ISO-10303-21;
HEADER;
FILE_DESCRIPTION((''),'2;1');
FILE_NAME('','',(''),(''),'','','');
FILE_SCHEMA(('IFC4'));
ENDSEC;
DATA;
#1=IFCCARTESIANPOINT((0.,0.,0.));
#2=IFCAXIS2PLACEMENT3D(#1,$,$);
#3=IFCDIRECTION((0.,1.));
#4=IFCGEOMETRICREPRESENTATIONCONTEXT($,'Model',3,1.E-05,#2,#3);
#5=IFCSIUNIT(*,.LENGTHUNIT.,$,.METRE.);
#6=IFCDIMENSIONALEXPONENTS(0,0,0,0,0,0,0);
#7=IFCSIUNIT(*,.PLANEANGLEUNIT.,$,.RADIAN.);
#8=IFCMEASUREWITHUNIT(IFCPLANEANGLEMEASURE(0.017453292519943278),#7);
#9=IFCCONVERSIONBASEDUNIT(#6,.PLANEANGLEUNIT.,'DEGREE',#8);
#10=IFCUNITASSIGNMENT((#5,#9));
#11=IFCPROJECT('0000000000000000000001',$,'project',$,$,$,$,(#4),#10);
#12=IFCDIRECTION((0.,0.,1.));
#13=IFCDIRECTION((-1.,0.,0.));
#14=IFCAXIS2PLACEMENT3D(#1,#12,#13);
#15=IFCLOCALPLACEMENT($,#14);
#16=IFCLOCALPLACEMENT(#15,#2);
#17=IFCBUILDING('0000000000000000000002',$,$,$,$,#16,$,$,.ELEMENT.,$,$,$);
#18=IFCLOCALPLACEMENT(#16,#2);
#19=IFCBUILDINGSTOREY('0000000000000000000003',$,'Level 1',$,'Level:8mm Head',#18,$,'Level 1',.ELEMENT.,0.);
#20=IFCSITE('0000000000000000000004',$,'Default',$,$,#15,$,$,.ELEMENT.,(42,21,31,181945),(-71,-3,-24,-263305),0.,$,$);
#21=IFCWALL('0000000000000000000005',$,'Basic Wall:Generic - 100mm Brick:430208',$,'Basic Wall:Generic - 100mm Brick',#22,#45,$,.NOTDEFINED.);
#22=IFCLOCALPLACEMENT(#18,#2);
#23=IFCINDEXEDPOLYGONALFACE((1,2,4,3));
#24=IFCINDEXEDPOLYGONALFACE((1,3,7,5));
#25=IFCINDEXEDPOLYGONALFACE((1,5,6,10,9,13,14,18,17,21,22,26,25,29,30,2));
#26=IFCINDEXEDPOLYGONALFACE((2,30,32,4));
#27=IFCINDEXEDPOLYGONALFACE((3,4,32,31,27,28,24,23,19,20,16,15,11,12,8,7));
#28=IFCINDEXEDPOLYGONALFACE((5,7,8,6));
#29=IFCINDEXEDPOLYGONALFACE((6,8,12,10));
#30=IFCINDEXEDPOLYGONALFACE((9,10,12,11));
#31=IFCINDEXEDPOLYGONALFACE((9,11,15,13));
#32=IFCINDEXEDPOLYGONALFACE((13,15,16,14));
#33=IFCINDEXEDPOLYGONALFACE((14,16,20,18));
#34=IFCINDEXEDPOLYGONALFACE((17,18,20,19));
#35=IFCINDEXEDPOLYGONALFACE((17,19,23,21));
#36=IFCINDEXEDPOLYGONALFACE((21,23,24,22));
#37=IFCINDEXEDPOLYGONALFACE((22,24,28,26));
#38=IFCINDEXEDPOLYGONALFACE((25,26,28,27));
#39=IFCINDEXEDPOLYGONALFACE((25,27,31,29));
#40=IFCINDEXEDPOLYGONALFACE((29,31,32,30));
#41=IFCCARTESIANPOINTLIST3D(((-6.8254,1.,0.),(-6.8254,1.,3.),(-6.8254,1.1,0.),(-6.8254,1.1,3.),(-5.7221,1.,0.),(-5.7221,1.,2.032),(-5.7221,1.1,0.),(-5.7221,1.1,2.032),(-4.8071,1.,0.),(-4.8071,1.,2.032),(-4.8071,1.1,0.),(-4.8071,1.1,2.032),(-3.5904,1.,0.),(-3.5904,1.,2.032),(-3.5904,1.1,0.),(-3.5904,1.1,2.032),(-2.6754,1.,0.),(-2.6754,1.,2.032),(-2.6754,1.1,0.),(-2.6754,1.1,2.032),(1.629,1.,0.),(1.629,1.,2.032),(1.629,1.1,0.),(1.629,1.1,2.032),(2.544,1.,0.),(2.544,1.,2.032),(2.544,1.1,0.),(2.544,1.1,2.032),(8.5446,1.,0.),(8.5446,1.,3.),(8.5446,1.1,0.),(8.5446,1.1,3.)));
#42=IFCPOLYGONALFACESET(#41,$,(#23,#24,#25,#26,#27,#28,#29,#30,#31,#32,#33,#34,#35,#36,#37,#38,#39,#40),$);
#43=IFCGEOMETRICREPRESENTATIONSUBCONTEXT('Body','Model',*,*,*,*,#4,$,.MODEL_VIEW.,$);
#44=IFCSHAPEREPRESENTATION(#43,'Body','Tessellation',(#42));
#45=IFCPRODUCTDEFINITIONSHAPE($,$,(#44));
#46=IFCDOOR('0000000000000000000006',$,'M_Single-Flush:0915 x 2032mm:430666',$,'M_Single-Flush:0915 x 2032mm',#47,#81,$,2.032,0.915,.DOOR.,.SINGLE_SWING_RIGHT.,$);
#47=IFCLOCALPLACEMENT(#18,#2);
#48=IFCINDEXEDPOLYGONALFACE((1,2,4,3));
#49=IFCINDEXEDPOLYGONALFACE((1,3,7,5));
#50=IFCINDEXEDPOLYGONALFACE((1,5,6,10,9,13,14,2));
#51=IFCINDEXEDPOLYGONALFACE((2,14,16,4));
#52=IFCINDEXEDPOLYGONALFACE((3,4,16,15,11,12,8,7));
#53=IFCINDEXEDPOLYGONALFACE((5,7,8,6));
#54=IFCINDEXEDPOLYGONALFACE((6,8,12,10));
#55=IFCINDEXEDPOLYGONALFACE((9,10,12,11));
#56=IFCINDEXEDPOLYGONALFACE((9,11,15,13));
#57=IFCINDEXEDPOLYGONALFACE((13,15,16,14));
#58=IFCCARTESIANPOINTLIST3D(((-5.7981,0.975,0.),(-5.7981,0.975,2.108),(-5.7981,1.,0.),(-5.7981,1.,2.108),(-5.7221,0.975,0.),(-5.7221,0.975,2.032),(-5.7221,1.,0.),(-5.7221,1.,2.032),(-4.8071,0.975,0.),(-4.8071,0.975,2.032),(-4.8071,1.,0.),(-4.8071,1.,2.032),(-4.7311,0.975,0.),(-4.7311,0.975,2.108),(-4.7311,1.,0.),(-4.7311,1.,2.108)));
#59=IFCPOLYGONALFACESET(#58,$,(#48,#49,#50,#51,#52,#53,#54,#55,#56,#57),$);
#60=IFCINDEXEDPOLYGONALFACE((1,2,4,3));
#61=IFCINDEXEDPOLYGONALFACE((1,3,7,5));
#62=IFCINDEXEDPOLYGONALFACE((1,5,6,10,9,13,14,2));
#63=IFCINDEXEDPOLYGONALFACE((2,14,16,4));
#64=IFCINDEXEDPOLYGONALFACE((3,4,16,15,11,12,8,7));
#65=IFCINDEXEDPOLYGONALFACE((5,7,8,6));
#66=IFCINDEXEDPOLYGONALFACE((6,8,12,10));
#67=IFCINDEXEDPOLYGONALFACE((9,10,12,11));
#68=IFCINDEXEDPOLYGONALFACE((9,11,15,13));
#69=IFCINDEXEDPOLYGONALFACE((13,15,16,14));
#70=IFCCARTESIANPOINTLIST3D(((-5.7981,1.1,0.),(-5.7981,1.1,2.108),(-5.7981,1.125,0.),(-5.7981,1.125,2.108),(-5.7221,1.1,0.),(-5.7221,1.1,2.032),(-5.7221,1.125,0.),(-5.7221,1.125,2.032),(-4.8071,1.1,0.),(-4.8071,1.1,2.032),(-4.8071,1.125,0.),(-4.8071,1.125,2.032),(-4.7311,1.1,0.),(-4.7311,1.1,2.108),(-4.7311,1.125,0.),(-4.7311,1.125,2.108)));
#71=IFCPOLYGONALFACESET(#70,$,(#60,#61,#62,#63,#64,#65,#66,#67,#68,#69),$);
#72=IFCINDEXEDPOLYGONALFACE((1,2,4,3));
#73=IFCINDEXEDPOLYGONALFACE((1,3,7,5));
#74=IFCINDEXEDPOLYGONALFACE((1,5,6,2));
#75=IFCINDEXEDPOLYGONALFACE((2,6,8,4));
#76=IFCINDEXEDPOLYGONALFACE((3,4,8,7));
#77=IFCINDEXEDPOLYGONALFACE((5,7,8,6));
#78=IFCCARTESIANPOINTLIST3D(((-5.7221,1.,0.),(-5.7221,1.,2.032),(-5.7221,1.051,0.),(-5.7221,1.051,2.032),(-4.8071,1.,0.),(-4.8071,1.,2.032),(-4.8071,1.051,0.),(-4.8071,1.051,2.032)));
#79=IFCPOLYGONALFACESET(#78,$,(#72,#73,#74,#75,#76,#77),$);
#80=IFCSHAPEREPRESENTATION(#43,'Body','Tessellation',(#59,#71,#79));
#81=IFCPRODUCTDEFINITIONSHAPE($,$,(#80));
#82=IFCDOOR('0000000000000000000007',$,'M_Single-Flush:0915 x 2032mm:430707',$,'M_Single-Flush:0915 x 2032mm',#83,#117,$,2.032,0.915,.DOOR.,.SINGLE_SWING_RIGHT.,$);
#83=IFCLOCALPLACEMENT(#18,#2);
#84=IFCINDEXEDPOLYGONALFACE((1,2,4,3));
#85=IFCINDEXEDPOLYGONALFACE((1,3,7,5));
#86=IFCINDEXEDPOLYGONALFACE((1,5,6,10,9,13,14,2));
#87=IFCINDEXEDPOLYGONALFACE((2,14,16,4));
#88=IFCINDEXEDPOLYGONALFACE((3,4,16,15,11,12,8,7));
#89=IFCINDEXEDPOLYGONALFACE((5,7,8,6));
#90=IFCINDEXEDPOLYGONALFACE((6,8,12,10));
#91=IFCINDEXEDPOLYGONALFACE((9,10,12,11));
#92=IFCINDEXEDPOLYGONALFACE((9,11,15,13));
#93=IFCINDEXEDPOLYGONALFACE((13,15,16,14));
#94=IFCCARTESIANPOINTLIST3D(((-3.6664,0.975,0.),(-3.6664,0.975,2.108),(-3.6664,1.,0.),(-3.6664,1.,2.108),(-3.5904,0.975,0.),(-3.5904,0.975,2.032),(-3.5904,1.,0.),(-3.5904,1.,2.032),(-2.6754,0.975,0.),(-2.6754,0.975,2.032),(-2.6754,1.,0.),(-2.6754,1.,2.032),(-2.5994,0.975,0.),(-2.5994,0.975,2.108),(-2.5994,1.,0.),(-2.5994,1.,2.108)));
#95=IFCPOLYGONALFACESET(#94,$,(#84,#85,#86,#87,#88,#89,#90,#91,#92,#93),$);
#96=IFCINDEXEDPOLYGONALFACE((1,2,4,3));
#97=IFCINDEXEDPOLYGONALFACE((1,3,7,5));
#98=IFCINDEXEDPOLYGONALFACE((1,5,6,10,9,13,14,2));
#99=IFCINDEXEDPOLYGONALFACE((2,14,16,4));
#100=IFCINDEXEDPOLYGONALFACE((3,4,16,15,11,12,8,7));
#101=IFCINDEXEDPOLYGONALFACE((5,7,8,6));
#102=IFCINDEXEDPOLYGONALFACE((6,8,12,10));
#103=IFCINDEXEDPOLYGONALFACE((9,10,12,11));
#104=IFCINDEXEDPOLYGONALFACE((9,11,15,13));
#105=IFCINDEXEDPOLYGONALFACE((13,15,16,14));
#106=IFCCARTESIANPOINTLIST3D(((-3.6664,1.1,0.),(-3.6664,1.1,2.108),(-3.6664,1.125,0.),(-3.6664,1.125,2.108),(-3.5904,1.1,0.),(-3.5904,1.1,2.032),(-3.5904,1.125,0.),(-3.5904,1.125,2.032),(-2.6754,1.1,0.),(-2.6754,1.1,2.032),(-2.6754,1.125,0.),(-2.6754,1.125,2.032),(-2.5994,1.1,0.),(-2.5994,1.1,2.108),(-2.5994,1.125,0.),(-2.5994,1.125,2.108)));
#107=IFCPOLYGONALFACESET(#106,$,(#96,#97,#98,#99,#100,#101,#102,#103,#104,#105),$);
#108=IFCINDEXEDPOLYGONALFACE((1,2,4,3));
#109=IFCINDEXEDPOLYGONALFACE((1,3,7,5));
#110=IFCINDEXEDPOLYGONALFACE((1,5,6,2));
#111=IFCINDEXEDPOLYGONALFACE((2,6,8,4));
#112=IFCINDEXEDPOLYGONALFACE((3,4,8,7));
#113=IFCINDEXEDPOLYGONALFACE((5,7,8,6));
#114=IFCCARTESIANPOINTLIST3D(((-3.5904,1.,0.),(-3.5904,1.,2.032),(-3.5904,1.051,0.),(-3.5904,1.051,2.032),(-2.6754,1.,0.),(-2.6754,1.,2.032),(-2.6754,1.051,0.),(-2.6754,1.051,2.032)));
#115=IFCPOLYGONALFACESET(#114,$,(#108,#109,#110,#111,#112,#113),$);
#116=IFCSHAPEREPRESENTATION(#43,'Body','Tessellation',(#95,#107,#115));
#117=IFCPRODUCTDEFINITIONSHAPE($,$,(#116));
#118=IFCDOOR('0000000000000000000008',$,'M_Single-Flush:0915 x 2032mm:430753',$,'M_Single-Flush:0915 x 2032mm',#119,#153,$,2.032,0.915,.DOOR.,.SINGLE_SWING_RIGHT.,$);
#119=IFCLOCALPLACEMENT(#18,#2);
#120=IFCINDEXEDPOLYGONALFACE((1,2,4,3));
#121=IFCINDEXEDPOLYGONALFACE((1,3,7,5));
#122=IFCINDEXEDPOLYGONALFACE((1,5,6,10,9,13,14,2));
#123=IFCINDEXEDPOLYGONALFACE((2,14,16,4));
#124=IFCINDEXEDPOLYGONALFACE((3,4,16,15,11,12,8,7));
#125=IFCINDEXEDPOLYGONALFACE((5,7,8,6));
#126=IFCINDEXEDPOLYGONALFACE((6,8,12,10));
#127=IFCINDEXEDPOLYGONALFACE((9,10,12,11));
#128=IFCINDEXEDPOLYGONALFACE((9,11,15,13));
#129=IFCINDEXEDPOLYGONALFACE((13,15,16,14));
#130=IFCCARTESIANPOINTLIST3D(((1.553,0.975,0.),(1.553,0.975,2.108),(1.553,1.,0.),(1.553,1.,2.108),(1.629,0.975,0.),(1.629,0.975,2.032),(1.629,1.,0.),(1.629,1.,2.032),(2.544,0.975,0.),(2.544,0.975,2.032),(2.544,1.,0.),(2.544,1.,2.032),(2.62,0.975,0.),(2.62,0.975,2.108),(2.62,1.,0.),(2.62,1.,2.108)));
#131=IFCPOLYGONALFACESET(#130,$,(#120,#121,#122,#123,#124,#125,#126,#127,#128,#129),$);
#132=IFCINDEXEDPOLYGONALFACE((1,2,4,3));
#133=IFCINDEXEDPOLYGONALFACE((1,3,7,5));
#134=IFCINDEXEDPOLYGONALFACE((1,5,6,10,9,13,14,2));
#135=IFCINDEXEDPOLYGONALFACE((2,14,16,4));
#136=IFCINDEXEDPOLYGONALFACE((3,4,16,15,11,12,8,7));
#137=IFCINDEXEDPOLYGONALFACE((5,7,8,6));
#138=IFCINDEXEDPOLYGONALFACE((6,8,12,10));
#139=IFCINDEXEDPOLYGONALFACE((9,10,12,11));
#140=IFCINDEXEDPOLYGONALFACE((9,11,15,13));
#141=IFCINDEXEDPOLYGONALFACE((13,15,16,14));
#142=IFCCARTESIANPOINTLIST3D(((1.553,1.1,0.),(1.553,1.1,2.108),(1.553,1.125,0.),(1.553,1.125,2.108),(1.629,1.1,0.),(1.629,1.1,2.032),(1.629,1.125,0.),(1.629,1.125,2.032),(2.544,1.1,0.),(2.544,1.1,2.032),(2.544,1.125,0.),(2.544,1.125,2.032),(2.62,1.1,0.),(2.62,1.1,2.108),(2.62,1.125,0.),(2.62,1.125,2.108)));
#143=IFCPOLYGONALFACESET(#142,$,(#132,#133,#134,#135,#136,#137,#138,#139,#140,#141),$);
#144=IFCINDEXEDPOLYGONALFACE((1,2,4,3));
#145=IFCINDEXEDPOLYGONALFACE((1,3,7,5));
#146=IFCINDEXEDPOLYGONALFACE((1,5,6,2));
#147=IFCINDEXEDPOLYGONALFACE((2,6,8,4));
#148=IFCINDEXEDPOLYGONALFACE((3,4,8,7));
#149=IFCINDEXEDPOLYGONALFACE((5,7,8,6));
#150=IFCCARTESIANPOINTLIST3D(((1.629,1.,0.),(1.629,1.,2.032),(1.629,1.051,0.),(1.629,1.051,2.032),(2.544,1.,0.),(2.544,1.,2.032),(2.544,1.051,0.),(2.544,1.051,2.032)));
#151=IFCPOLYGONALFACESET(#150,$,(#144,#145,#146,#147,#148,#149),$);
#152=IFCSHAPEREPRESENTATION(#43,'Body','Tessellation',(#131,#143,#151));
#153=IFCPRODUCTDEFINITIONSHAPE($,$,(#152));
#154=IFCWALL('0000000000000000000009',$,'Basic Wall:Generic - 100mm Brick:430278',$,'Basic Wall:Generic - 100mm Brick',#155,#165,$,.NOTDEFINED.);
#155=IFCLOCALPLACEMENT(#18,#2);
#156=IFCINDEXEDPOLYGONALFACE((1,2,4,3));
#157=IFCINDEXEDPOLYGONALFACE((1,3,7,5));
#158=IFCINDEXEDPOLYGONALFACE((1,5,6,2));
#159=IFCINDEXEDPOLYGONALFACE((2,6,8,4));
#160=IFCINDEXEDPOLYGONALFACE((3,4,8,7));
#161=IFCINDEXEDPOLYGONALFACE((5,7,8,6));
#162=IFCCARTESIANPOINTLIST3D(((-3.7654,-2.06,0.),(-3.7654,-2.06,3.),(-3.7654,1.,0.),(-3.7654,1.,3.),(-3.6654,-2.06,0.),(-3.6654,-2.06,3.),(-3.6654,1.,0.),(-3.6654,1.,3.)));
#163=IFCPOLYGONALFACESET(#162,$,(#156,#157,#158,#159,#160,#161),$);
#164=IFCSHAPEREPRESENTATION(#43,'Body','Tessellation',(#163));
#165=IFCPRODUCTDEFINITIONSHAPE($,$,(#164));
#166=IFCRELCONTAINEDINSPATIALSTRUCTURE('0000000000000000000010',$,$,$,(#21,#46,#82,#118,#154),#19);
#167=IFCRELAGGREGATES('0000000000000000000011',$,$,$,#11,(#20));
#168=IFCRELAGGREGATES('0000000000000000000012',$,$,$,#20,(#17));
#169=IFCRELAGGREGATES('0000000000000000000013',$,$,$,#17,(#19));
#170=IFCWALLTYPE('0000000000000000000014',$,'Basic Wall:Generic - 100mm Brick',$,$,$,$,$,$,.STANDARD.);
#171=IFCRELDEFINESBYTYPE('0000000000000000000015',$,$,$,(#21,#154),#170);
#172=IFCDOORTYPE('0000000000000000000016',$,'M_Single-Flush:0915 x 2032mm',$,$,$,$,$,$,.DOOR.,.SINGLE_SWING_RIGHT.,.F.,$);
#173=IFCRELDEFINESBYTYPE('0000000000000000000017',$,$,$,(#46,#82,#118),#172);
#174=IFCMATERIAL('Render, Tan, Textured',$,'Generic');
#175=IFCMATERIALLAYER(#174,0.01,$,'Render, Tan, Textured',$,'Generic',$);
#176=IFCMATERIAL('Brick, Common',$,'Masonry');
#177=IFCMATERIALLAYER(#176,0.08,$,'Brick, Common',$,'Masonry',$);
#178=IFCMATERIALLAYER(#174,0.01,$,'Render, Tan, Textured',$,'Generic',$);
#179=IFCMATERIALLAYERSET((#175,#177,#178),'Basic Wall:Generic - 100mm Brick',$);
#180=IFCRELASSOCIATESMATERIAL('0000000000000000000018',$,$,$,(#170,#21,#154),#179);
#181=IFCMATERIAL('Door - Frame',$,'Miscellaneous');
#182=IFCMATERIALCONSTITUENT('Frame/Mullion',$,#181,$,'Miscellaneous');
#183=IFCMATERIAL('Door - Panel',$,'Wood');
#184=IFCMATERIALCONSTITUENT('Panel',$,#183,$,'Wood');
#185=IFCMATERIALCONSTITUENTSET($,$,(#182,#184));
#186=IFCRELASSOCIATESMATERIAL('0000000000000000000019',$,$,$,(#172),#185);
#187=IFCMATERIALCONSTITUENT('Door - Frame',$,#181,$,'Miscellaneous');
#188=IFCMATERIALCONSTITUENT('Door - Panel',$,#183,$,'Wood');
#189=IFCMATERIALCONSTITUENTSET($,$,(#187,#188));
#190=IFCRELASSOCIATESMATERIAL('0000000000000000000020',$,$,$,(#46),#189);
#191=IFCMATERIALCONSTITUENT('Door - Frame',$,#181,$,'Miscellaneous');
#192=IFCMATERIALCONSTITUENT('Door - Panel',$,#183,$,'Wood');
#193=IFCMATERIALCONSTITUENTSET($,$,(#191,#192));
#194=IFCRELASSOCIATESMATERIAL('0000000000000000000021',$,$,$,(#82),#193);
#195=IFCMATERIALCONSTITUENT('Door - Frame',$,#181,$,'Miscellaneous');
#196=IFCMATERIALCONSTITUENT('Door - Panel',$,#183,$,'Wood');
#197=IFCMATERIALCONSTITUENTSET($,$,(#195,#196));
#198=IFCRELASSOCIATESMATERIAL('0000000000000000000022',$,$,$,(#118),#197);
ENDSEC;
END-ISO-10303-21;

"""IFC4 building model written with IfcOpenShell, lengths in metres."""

from ifc_helpers import new_model, entity, si_unit, converted_unit, direction, frame, frame_2d, origin, place, context, subcontext, project, spatial, polyline, rectangle, outline, extrude, source, transform, mapped, material, layer, layer_set, layer_usage, constituent, constituent_set, type_object, type_shapes, element, fill, save


model = new_model("IFC4")

# Units and contexts
model_context = context("Model", 3, precision=1e-05, world=origin(), true_north=direction((0.0, 1.0)))
body_context = subcontext(model_context, "Body", "Model", "MODEL_VIEW")
ifc_project = project(units=[si_unit("LENGTHUNIT", "METRE"), converted_unit("PLANEANGLEUNIT", "DEGREE", entity("IfcPlaneAngleMeasure", 0.017453292519943278), si_unit("PLANEANGLEUNIT", "RADIAN"), dimensions=[0, 0, 0, 0, 0, 0, 0])], contexts=[model_context])

# Site, building, storey
site_placement = place(None, frame((0.0, 0.0, 0.0), z_axis=(0.0, 0.0, 1.0), x_axis=(-1.0, 0.0, 0.0)))
site = spatial("IfcSite", under=ifc_project, at=site_placement, Name="Default", CompositionType="ELEMENT", RefLatitude=(42, 21, 31, 181945), RefLongitude=(-71, -3, -24, -263305), RefElevation=0.0)
building_placement = place(site_placement, origin())
building = spatial("IfcBuilding", under=site, at=building_placement, CompositionType="ELEMENT")
storey_placement = place(building_placement, origin())
storey = spatial("IfcBuildingStorey", under=building, at=storey_placement, Name="Level 1", ObjectType="Level:8mm Head", LongName="Level 1", CompositionType="ELEMENT", Elevation=0.0)

# Shared definitions
ifc_material_1 = material(Name="Brick, Common", Category="Masonry")

# Shared definitions
ifc_material_2 = material(Name="Render, Tan, Textured", Category="Generic")
ifc_layer_1 = layer(ifc_material_2, 0.01, Name="Render, Tan, Textured", Category="Generic")
ifc_layer_2 = layer(ifc_material_1, 0.08, Name="Brick, Common", Category="Masonry")
ifc_layer_3 = layer(ifc_material_2, 0.01, Name="Render, Tan, Textured", Category="Generic")
ifc_layer_set_1 = layer_set([ifc_layer_1, ifc_layer_2, ifc_layer_3], Name="Basic Wall:Generic - 100mm Brick")
ifc_layer_usage_1 = layer_usage(ifc_layer_set_1, "AXIS2", "NEGATIVE", 0.05)
wall_type_1 = type_object("IfcWallType", Name="Basic Wall:Generic - 100mm Brick", PredefinedType="STANDARD", material=ifc_layer_set_1)

# Shared definitions
ifc_material_3 = material(Name="Door - Frame", Category="Miscellaneous")
ifc_material_4 = material(Name="Door - Panel", Category="Wood")

# Wall, openings, doors
wall_1_placement = place(storey_placement, frame((-6.8254, 1.05, 0.0)))
wall_1 = element("IfcWall", 1, at=wall_1_placement, inside=storey, type_object=wall_type_1, material=ifc_layer_usage_1, Name="Basic Wall:Generic - 100mm Brick:430208", ObjectType="Basic Wall:Generic - 100mm Brick", PredefinedType="NOTDEFINED", context=body_context, shape_type="SweptSolid", body=[
    extrude(rectangle(XDim=15.37, YDim=0.1, at=frame_2d((7.685, 0.0), x_axis=(-1.0, 0.0))), origin(), (0.0, 0.0, 1.0), 3.0),
])
opening_1_placement = place(wall_1_placement, frame((2.0183, 0.05, 0.0)))
opening_1 = element("IfcOpeningElement", 2, at=opening_1_placement, cuts=wall_1, PredefinedType="OPENING", context=body_context, shape_type="SweptSolid", body=[
    extrude(rectangle(XDim=0.915, YDim=2.032, at=frame_2d((1.016, 0.4575), x_axis=(0.0, 1.0))), frame((0.0, 0.0, 0.0), z_axis=(0.0, -1.0, 0.0), x_axis=(0.0, 0.0, 1.0)), (0.0, 0.0, 1.0), 0.1),
])
opening_2_placement = place(wall_1_placement, frame((4.15, 0.05, 0.0)))
opening_2 = element("IfcOpeningElement", 3, at=opening_2_placement, cuts=wall_1, PredefinedType="OPENING", context=body_context, shape_type="SweptSolid", body=[
    extrude(rectangle(XDim=0.915, YDim=2.032, at=frame_2d((1.016, 0.4575), x_axis=(0.0, 1.0))), frame((0.0, 0.0, 0.0), z_axis=(0.0, -1.0, 0.0), x_axis=(0.0, 0.0, 1.0)), (0.0, 0.0, 1.0), 0.1),
])
opening_3_placement = place(wall_1_placement, frame((9.3694, 0.05, 0.0)))
opening_3 = element("IfcOpeningElement", 4, at=opening_3_placement, cuts=wall_1, PredefinedType="OPENING", context=body_context, shape_type="SweptSolid", body=[
    extrude(rectangle(XDim=0.915, YDim=2.032, at=frame_2d((1.016, 0.4575), x_axis=(0.0, 1.0))), frame((0.0, 0.0, 0.0), z_axis=(0.0, -1.0, 0.0), x_axis=(0.0, 0.0, 1.0)), (0.0, 0.0, 1.0), 0.1),
])
ifc_constituent_1 = constituent(ifc_material_3, Name="Door - Frame", Category="Miscellaneous")
ifc_constituent_2 = constituent(ifc_material_4, Name="Door - Panel", Category="Wood")
ifc_constituent_set_1 = constituent_set(constituents=[ifc_constituent_1, ifc_constituent_2])
ifc_constituent_3 = constituent(ifc_material_3, Name="Frame/Mullion", Category="Miscellaneous")
ifc_constituent_4 = constituent(ifc_material_4, Name="Panel", Category="Wood")
ifc_constituent_set_2 = constituent_set(constituents=[ifc_constituent_3, ifc_constituent_4])
door_type_1 = type_object("IfcDoorType", Name="M_Single-Flush:0915 x 2032mm", OperationType="SINGLE_SWING_RIGHT", ParameterTakesPrecedence=False, PredefinedType="DOOR", material=ifc_constituent_set_2)
shared_shape_1 = source(origin(), body_context, "Body", "SweptSolid", [
    extrude(outline(polyline([(-0.5335, -1.073), (0.5335, -1.073), (0.5335, 1.035), (0.4575, 1.035), (0.4575, -0.997), (-0.4575, -0.997), (-0.4575, 1.035), (-0.5335, 1.035), (-0.5335, -1.073)])), frame((0.4575, 0.1, 1.035), z_axis=(0.0, 1.0, 0.0), x_axis=(1.0, 0.0, 0.0)), (0.0, 0.0, 1.0), 0.025),
    extrude(outline(polyline([(-1.073, -0.5335), (1.035, -0.5335), (1.035, -0.4575), (-0.997, -0.4575), (-0.997, 0.4575), (1.035, 0.4575), (1.035, 0.5335), (-1.073, 0.5335), (-1.073, -0.5335)])), frame((0.4575, -0.025, 1.035), z_axis=(0.0, 1.0, 0.0), x_axis=(0.0, 0.0, -1.0)), (0.0, 0.0, 1.0), 0.025),
    extrude(rectangle(XDim=0.051, YDim=0.915, at=frame_2d((0.0, 0.0), x_axis=(1.0, 0.0))), frame((0.4575, 0.0745, 0.0), z_axis=(0.0, 0.0, 1.0), x_axis=(0.0, 1.0, 0.0)), (0.0, 0.0, 1.0), 2.032),
])
type_shapes(door_type_1, [shared_shape_1])
door_1_placement = place(opening_1_placement, frame((0.0, 0.0, 0.0), z_axis=(0.0, 0.0, 1.0), x_axis=(-1.0, 0.0, 0.0)))
door_1 = element("IfcDoor", 5, at=door_1_placement, inside=storey, type_object=door_type_1, material=ifc_constituent_set_1, Name="M_Single-Flush:0915 x 2032mm:430666", ObjectType="M_Single-Flush:0915 x 2032mm", OperationType="SINGLE_SWING_RIGHT", OverallHeight=2.032, OverallWidth=0.915, PredefinedType="DOOR", context=body_context, shape_type="MappedRepresentation", body=[
    mapped(shared_shape_1, transform((0.0, 0.0, 0.0), scale=1.0)),
])
fill(opening_1, door_1)
ifc_constituent_5 = constituent(ifc_material_3, Name="Door - Frame", Category="Miscellaneous")
ifc_constituent_6 = constituent(ifc_material_4, Name="Door - Panel", Category="Wood")
ifc_constituent_set_3 = constituent_set(constituents=[ifc_constituent_5, ifc_constituent_6])
door_2_placement = place(opening_2_placement, frame((0.0, 0.0, 0.0), z_axis=(0.0, 0.0, 1.0), x_axis=(-1.0, 0.0, 0.0)))
door_2 = element("IfcDoor", 6, at=door_2_placement, inside=storey, type_object=door_type_1, material=ifc_constituent_set_3, Name="M_Single-Flush:0915 x 2032mm:430707", ObjectType="M_Single-Flush:0915 x 2032mm", OperationType="SINGLE_SWING_RIGHT", OverallHeight=2.032, OverallWidth=0.915, PredefinedType="DOOR", context=body_context, shape_type="MappedRepresentation", body=[
    mapped(shared_shape_1, transform((0.0, 0.0, 0.0), scale=1.0)),
])
fill(opening_2, door_2)
ifc_constituent_7 = constituent(ifc_material_3, Name="Door - Frame", Category="Miscellaneous")
ifc_constituent_8 = constituent(ifc_material_4, Name="Door - Panel", Category="Wood")
ifc_constituent_set_4 = constituent_set(constituents=[ifc_constituent_7, ifc_constituent_8])
door_3_placement = place(opening_3_placement, frame((0.0, 0.0, 0.0), z_axis=(0.0, 0.0, 1.0), x_axis=(-1.0, 0.0, 0.0)))
door_3 = element("IfcDoor", 7, at=door_3_placement, inside=storey, type_object=door_type_1, material=ifc_constituent_set_4, Name="M_Single-Flush:0915 x 2032mm:430753", ObjectType="M_Single-Flush:0915 x 2032mm", OperationType="SINGLE_SWING_RIGHT", OverallHeight=2.032, OverallWidth=0.915, PredefinedType="DOOR", context=body_context, shape_type="MappedRepresentation", body=[
    mapped(shared_shape_1, transform((0.0, 0.0, 0.0), scale=1.0)),
])
fill(opening_3, door_3)

# Wall
wall_2_placement = place(storey_placement, frame((-3.7154, 1.0, 0.0), z_axis=(0.0, 0.0, 1.0), x_axis=(0.0, -1.0, 0.0)))
element("IfcWall", 8, at=wall_2_placement, inside=storey, type_object=wall_type_1, material=ifc_layer_usage_1, Name="Basic Wall:Generic - 100mm Brick:430278", ObjectType="Basic Wall:Generic - 100mm Brick", PredefinedType="NOTDEFINED", context=body_context, shape_type="SweptSolid", body=[
    extrude(rectangle(XDim=3.06, YDim=0.1, at=frame_2d((1.53, 0.0), x_axis=(-1.0, 0.0))), origin(), (0.0, 0.0, 1.0), 3.0),
])

save(model, "model.ifc")
